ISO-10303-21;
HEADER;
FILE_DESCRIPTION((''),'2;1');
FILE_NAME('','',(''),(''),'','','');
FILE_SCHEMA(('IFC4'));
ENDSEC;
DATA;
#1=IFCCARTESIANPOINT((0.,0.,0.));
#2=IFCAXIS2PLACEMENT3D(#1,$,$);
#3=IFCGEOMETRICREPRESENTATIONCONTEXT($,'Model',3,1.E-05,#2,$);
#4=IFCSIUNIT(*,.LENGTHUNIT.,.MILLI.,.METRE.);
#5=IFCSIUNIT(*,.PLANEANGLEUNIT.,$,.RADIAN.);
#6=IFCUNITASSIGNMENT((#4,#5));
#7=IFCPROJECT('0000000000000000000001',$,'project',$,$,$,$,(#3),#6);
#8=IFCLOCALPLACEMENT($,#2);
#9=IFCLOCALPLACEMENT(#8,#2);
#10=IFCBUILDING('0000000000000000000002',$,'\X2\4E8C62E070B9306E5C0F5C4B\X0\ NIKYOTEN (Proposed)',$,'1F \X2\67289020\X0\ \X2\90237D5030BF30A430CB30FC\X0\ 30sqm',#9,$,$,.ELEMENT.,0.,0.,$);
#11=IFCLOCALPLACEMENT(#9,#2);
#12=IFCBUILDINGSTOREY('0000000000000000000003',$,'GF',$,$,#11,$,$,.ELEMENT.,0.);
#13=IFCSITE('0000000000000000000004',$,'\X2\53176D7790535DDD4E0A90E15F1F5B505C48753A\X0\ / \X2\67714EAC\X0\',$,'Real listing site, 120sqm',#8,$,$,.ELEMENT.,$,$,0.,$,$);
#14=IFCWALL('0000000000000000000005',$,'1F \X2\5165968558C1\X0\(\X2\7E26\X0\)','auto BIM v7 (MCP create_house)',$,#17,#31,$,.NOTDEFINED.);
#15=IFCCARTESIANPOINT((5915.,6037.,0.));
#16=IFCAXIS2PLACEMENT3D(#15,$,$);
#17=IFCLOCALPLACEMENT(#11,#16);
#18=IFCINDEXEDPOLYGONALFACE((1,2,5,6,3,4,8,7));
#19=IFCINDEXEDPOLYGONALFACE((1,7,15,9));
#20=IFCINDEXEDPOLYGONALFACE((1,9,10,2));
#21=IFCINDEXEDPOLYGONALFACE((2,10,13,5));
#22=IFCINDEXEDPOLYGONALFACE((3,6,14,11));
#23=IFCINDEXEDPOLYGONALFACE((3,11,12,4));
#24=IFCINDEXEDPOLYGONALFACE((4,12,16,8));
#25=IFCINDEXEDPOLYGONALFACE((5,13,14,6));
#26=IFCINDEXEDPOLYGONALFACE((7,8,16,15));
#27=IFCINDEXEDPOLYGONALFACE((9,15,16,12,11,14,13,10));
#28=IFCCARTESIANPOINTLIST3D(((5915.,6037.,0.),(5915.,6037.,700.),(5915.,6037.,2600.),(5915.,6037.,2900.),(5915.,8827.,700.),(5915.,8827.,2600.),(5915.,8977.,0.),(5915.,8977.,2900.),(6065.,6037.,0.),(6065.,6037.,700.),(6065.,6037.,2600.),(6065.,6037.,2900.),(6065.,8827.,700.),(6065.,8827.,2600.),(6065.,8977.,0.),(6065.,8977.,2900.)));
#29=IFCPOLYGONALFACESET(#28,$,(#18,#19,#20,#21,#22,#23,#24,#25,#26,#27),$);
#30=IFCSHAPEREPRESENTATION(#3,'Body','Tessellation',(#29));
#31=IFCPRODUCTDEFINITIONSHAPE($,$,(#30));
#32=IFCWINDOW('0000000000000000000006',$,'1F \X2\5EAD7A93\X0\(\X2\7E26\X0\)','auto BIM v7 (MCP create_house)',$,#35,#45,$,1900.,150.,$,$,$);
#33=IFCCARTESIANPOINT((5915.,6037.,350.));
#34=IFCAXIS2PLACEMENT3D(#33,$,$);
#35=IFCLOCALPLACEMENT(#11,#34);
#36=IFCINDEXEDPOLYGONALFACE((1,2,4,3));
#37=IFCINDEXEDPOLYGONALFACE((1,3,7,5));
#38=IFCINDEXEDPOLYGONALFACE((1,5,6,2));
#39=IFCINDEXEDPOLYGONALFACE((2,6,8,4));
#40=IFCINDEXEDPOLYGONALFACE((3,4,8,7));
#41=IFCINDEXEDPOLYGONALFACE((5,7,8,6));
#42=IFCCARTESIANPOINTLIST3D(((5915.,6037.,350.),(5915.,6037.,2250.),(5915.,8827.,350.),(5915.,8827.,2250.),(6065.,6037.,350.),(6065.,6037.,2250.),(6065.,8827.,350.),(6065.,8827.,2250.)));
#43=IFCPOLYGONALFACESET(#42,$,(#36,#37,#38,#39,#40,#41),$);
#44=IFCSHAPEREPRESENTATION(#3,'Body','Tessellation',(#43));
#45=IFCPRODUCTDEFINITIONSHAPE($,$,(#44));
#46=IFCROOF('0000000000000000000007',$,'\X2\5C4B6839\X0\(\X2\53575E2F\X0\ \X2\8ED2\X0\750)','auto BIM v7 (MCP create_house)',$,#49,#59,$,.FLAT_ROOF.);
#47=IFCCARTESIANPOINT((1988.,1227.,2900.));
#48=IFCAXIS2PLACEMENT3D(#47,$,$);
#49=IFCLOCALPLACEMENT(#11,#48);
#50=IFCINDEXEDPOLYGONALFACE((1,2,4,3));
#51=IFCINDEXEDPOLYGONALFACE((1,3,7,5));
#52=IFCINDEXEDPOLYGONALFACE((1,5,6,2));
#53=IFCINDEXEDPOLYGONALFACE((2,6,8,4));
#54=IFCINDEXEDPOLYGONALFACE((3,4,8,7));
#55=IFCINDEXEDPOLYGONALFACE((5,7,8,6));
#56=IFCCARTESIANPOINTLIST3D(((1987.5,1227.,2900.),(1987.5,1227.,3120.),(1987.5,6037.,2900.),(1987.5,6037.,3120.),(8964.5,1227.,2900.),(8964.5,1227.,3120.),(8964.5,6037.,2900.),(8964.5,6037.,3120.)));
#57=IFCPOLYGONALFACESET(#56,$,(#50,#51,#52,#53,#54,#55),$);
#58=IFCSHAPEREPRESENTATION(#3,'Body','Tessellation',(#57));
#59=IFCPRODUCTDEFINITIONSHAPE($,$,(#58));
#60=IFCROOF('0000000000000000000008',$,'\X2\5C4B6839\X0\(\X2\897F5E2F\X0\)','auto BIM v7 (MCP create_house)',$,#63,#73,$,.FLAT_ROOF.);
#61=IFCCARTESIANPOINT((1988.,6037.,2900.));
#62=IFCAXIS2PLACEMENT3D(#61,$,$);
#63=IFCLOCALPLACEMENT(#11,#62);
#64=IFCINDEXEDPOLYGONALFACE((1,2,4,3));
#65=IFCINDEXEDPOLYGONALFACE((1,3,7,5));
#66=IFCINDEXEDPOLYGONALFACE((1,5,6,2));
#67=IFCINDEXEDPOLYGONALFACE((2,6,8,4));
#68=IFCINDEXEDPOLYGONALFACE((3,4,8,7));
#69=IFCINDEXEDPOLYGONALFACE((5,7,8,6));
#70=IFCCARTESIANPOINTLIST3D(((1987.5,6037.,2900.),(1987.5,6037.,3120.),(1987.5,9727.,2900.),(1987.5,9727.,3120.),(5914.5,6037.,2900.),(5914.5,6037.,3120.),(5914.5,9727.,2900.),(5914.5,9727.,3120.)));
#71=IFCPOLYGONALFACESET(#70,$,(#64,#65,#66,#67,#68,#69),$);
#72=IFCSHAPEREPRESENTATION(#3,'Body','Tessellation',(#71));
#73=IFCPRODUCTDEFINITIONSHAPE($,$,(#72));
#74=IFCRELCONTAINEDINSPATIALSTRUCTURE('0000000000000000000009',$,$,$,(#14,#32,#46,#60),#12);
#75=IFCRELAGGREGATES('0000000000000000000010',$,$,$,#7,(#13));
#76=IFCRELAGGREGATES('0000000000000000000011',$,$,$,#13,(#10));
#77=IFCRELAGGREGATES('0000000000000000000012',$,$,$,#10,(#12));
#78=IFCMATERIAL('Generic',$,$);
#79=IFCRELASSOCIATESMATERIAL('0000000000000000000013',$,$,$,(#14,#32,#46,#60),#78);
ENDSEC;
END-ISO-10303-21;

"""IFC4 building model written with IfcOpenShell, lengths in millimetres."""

from ifc_helpers import new_model, si_unit, frame, frame_2d, origin, place, context, project, spatial, rectangle, extrude, material, element, fill, save


model = new_model("IFC4")

# Units and contexts
model_context = context("Model", 3, precision=1e-05, world=origin())
ifc_project = project(units=[si_unit("LENGTHUNIT", "METRE", prefix="MILLI"), si_unit("PLANEANGLEUNIT", "RADIAN")], contexts=[model_context])

# Site, building, storey
site_placement = place(None, origin())
site = spatial("IfcSite", under=ifc_project, at=site_placement, Name="北海道川上郡弟子屈町 / 東京", ObjectType="Real listing site, 120sqm", CompositionType="ELEMENT", RefElevation=0.0)
building_placement = place(site_placement, origin())
building = spatial("IfcBuilding", under=site, at=building_placement, Name="二拠点の小屋 NIKYOTEN (Proposed)", ObjectType="1F 木造 連結タイニー 30sqm", CompositionType="ELEMENT", ElevationOfRefHeight=0.0, ElevationOfTerrain=0.0)
storey_placement = place(building_placement, origin())
storey = spatial("IfcBuildingStorey", under=building, at=storey_placement, Name="GF", CompositionType="ELEMENT", Elevation=0.0)

# Shared definitions
ifc_material = material(Name="Generic")

# Wall, opening, window
wall_1_placement = place(storey_placement, frame((5915.0, 6037.0, 0.0)))
wall_1 = element("IfcWall", 1, at=wall_1_placement, inside=storey, material=ifc_material, Name="1F 入隅壁(縦)", Description="auto BIM v7 (MCP create_house)", PredefinedType="NOTDEFINED", context=model_context, shape_type="SweptSolid", body=[
    extrude(rectangle(XDim=150.0, YDim=2940.0, at=frame_2d((75.0, 1470.0))), frame((5915.0, 6037.0, 0.0)), (0.0, 0.0, 1.0), 2900.0),
])
opening_1_placement = place(storey_placement, frame((5915.0, 6037.0, 350.0)))
opening_1 = element("IfcOpeningElement", 2, at=opening_1_placement, cuts=wall_1, PredefinedType="NOTDEFINED", context=model_context, shape_type="SweptSolid", body=[
    extrude(rectangle(XDim=150.0, YDim=2790.0, at=frame_2d((75.0, 1395.0))), frame((5915.0, 6037.0, 350.0)), (0.0, 0.0, 1.0), 1900.0),
])
window_1_placement = place(storey_placement, frame((5915.0, 6037.0, 350.0)))
window_1 = element("IfcWindow", 3, at=window_1_placement, inside=storey, material=ifc_material, Name="1F 庭窓(縦)", Description="auto BIM v7 (MCP create_house)", OverallHeight=1900.0, OverallWidth=150.0, context=model_context, shape_type="SweptSolid", body=[
    extrude(rectangle(XDim=150.0, YDim=2790.0, at=frame_2d((75.0, 1395.0))), frame((5915.0, 6037.0, 350.0)), (0.0, 0.0, 1.0), 1900.0),
])
fill(opening_1, window_1)

# Roofs
roof_1_placement = place(storey_placement, frame((1988.0, 1227.0, 2900.0)))
element("IfcRoof", 4, at=roof_1_placement, inside=storey, material=ifc_material, Name="屋根(南帯 軒750)", Description="auto BIM v7 (MCP create_house)", PredefinedType="FLAT_ROOF", context=model_context, shape_type="SweptSolid", body=[
    extrude(rectangle(XDim=6977.0, YDim=4810.0, at=frame_2d((3488.0, 2405.0))), frame((1988.0, 1227.0, 2900.0)), (0.0, 0.0, 1.0), 220.0),
])
roof_2_placement = place(storey_placement, frame((1988.0, 6037.0, 2900.0)))
element("IfcRoof", 5, at=roof_2_placement, inside=storey, material=ifc_material, Name="屋根(西帯)", Description="auto BIM v7 (MCP create_house)", PredefinedType="FLAT_ROOF", context=model_context, shape_type="SweptSolid", body=[
    extrude(rectangle(XDim=3927.0, YDim=3690.0, at=frame_2d((1963.0, 1845.0))), frame((1988.0, 6037.0, 2900.0)), (0.0, 0.0, 1.0), 220.0),
])

save(model, "model.ifc")
